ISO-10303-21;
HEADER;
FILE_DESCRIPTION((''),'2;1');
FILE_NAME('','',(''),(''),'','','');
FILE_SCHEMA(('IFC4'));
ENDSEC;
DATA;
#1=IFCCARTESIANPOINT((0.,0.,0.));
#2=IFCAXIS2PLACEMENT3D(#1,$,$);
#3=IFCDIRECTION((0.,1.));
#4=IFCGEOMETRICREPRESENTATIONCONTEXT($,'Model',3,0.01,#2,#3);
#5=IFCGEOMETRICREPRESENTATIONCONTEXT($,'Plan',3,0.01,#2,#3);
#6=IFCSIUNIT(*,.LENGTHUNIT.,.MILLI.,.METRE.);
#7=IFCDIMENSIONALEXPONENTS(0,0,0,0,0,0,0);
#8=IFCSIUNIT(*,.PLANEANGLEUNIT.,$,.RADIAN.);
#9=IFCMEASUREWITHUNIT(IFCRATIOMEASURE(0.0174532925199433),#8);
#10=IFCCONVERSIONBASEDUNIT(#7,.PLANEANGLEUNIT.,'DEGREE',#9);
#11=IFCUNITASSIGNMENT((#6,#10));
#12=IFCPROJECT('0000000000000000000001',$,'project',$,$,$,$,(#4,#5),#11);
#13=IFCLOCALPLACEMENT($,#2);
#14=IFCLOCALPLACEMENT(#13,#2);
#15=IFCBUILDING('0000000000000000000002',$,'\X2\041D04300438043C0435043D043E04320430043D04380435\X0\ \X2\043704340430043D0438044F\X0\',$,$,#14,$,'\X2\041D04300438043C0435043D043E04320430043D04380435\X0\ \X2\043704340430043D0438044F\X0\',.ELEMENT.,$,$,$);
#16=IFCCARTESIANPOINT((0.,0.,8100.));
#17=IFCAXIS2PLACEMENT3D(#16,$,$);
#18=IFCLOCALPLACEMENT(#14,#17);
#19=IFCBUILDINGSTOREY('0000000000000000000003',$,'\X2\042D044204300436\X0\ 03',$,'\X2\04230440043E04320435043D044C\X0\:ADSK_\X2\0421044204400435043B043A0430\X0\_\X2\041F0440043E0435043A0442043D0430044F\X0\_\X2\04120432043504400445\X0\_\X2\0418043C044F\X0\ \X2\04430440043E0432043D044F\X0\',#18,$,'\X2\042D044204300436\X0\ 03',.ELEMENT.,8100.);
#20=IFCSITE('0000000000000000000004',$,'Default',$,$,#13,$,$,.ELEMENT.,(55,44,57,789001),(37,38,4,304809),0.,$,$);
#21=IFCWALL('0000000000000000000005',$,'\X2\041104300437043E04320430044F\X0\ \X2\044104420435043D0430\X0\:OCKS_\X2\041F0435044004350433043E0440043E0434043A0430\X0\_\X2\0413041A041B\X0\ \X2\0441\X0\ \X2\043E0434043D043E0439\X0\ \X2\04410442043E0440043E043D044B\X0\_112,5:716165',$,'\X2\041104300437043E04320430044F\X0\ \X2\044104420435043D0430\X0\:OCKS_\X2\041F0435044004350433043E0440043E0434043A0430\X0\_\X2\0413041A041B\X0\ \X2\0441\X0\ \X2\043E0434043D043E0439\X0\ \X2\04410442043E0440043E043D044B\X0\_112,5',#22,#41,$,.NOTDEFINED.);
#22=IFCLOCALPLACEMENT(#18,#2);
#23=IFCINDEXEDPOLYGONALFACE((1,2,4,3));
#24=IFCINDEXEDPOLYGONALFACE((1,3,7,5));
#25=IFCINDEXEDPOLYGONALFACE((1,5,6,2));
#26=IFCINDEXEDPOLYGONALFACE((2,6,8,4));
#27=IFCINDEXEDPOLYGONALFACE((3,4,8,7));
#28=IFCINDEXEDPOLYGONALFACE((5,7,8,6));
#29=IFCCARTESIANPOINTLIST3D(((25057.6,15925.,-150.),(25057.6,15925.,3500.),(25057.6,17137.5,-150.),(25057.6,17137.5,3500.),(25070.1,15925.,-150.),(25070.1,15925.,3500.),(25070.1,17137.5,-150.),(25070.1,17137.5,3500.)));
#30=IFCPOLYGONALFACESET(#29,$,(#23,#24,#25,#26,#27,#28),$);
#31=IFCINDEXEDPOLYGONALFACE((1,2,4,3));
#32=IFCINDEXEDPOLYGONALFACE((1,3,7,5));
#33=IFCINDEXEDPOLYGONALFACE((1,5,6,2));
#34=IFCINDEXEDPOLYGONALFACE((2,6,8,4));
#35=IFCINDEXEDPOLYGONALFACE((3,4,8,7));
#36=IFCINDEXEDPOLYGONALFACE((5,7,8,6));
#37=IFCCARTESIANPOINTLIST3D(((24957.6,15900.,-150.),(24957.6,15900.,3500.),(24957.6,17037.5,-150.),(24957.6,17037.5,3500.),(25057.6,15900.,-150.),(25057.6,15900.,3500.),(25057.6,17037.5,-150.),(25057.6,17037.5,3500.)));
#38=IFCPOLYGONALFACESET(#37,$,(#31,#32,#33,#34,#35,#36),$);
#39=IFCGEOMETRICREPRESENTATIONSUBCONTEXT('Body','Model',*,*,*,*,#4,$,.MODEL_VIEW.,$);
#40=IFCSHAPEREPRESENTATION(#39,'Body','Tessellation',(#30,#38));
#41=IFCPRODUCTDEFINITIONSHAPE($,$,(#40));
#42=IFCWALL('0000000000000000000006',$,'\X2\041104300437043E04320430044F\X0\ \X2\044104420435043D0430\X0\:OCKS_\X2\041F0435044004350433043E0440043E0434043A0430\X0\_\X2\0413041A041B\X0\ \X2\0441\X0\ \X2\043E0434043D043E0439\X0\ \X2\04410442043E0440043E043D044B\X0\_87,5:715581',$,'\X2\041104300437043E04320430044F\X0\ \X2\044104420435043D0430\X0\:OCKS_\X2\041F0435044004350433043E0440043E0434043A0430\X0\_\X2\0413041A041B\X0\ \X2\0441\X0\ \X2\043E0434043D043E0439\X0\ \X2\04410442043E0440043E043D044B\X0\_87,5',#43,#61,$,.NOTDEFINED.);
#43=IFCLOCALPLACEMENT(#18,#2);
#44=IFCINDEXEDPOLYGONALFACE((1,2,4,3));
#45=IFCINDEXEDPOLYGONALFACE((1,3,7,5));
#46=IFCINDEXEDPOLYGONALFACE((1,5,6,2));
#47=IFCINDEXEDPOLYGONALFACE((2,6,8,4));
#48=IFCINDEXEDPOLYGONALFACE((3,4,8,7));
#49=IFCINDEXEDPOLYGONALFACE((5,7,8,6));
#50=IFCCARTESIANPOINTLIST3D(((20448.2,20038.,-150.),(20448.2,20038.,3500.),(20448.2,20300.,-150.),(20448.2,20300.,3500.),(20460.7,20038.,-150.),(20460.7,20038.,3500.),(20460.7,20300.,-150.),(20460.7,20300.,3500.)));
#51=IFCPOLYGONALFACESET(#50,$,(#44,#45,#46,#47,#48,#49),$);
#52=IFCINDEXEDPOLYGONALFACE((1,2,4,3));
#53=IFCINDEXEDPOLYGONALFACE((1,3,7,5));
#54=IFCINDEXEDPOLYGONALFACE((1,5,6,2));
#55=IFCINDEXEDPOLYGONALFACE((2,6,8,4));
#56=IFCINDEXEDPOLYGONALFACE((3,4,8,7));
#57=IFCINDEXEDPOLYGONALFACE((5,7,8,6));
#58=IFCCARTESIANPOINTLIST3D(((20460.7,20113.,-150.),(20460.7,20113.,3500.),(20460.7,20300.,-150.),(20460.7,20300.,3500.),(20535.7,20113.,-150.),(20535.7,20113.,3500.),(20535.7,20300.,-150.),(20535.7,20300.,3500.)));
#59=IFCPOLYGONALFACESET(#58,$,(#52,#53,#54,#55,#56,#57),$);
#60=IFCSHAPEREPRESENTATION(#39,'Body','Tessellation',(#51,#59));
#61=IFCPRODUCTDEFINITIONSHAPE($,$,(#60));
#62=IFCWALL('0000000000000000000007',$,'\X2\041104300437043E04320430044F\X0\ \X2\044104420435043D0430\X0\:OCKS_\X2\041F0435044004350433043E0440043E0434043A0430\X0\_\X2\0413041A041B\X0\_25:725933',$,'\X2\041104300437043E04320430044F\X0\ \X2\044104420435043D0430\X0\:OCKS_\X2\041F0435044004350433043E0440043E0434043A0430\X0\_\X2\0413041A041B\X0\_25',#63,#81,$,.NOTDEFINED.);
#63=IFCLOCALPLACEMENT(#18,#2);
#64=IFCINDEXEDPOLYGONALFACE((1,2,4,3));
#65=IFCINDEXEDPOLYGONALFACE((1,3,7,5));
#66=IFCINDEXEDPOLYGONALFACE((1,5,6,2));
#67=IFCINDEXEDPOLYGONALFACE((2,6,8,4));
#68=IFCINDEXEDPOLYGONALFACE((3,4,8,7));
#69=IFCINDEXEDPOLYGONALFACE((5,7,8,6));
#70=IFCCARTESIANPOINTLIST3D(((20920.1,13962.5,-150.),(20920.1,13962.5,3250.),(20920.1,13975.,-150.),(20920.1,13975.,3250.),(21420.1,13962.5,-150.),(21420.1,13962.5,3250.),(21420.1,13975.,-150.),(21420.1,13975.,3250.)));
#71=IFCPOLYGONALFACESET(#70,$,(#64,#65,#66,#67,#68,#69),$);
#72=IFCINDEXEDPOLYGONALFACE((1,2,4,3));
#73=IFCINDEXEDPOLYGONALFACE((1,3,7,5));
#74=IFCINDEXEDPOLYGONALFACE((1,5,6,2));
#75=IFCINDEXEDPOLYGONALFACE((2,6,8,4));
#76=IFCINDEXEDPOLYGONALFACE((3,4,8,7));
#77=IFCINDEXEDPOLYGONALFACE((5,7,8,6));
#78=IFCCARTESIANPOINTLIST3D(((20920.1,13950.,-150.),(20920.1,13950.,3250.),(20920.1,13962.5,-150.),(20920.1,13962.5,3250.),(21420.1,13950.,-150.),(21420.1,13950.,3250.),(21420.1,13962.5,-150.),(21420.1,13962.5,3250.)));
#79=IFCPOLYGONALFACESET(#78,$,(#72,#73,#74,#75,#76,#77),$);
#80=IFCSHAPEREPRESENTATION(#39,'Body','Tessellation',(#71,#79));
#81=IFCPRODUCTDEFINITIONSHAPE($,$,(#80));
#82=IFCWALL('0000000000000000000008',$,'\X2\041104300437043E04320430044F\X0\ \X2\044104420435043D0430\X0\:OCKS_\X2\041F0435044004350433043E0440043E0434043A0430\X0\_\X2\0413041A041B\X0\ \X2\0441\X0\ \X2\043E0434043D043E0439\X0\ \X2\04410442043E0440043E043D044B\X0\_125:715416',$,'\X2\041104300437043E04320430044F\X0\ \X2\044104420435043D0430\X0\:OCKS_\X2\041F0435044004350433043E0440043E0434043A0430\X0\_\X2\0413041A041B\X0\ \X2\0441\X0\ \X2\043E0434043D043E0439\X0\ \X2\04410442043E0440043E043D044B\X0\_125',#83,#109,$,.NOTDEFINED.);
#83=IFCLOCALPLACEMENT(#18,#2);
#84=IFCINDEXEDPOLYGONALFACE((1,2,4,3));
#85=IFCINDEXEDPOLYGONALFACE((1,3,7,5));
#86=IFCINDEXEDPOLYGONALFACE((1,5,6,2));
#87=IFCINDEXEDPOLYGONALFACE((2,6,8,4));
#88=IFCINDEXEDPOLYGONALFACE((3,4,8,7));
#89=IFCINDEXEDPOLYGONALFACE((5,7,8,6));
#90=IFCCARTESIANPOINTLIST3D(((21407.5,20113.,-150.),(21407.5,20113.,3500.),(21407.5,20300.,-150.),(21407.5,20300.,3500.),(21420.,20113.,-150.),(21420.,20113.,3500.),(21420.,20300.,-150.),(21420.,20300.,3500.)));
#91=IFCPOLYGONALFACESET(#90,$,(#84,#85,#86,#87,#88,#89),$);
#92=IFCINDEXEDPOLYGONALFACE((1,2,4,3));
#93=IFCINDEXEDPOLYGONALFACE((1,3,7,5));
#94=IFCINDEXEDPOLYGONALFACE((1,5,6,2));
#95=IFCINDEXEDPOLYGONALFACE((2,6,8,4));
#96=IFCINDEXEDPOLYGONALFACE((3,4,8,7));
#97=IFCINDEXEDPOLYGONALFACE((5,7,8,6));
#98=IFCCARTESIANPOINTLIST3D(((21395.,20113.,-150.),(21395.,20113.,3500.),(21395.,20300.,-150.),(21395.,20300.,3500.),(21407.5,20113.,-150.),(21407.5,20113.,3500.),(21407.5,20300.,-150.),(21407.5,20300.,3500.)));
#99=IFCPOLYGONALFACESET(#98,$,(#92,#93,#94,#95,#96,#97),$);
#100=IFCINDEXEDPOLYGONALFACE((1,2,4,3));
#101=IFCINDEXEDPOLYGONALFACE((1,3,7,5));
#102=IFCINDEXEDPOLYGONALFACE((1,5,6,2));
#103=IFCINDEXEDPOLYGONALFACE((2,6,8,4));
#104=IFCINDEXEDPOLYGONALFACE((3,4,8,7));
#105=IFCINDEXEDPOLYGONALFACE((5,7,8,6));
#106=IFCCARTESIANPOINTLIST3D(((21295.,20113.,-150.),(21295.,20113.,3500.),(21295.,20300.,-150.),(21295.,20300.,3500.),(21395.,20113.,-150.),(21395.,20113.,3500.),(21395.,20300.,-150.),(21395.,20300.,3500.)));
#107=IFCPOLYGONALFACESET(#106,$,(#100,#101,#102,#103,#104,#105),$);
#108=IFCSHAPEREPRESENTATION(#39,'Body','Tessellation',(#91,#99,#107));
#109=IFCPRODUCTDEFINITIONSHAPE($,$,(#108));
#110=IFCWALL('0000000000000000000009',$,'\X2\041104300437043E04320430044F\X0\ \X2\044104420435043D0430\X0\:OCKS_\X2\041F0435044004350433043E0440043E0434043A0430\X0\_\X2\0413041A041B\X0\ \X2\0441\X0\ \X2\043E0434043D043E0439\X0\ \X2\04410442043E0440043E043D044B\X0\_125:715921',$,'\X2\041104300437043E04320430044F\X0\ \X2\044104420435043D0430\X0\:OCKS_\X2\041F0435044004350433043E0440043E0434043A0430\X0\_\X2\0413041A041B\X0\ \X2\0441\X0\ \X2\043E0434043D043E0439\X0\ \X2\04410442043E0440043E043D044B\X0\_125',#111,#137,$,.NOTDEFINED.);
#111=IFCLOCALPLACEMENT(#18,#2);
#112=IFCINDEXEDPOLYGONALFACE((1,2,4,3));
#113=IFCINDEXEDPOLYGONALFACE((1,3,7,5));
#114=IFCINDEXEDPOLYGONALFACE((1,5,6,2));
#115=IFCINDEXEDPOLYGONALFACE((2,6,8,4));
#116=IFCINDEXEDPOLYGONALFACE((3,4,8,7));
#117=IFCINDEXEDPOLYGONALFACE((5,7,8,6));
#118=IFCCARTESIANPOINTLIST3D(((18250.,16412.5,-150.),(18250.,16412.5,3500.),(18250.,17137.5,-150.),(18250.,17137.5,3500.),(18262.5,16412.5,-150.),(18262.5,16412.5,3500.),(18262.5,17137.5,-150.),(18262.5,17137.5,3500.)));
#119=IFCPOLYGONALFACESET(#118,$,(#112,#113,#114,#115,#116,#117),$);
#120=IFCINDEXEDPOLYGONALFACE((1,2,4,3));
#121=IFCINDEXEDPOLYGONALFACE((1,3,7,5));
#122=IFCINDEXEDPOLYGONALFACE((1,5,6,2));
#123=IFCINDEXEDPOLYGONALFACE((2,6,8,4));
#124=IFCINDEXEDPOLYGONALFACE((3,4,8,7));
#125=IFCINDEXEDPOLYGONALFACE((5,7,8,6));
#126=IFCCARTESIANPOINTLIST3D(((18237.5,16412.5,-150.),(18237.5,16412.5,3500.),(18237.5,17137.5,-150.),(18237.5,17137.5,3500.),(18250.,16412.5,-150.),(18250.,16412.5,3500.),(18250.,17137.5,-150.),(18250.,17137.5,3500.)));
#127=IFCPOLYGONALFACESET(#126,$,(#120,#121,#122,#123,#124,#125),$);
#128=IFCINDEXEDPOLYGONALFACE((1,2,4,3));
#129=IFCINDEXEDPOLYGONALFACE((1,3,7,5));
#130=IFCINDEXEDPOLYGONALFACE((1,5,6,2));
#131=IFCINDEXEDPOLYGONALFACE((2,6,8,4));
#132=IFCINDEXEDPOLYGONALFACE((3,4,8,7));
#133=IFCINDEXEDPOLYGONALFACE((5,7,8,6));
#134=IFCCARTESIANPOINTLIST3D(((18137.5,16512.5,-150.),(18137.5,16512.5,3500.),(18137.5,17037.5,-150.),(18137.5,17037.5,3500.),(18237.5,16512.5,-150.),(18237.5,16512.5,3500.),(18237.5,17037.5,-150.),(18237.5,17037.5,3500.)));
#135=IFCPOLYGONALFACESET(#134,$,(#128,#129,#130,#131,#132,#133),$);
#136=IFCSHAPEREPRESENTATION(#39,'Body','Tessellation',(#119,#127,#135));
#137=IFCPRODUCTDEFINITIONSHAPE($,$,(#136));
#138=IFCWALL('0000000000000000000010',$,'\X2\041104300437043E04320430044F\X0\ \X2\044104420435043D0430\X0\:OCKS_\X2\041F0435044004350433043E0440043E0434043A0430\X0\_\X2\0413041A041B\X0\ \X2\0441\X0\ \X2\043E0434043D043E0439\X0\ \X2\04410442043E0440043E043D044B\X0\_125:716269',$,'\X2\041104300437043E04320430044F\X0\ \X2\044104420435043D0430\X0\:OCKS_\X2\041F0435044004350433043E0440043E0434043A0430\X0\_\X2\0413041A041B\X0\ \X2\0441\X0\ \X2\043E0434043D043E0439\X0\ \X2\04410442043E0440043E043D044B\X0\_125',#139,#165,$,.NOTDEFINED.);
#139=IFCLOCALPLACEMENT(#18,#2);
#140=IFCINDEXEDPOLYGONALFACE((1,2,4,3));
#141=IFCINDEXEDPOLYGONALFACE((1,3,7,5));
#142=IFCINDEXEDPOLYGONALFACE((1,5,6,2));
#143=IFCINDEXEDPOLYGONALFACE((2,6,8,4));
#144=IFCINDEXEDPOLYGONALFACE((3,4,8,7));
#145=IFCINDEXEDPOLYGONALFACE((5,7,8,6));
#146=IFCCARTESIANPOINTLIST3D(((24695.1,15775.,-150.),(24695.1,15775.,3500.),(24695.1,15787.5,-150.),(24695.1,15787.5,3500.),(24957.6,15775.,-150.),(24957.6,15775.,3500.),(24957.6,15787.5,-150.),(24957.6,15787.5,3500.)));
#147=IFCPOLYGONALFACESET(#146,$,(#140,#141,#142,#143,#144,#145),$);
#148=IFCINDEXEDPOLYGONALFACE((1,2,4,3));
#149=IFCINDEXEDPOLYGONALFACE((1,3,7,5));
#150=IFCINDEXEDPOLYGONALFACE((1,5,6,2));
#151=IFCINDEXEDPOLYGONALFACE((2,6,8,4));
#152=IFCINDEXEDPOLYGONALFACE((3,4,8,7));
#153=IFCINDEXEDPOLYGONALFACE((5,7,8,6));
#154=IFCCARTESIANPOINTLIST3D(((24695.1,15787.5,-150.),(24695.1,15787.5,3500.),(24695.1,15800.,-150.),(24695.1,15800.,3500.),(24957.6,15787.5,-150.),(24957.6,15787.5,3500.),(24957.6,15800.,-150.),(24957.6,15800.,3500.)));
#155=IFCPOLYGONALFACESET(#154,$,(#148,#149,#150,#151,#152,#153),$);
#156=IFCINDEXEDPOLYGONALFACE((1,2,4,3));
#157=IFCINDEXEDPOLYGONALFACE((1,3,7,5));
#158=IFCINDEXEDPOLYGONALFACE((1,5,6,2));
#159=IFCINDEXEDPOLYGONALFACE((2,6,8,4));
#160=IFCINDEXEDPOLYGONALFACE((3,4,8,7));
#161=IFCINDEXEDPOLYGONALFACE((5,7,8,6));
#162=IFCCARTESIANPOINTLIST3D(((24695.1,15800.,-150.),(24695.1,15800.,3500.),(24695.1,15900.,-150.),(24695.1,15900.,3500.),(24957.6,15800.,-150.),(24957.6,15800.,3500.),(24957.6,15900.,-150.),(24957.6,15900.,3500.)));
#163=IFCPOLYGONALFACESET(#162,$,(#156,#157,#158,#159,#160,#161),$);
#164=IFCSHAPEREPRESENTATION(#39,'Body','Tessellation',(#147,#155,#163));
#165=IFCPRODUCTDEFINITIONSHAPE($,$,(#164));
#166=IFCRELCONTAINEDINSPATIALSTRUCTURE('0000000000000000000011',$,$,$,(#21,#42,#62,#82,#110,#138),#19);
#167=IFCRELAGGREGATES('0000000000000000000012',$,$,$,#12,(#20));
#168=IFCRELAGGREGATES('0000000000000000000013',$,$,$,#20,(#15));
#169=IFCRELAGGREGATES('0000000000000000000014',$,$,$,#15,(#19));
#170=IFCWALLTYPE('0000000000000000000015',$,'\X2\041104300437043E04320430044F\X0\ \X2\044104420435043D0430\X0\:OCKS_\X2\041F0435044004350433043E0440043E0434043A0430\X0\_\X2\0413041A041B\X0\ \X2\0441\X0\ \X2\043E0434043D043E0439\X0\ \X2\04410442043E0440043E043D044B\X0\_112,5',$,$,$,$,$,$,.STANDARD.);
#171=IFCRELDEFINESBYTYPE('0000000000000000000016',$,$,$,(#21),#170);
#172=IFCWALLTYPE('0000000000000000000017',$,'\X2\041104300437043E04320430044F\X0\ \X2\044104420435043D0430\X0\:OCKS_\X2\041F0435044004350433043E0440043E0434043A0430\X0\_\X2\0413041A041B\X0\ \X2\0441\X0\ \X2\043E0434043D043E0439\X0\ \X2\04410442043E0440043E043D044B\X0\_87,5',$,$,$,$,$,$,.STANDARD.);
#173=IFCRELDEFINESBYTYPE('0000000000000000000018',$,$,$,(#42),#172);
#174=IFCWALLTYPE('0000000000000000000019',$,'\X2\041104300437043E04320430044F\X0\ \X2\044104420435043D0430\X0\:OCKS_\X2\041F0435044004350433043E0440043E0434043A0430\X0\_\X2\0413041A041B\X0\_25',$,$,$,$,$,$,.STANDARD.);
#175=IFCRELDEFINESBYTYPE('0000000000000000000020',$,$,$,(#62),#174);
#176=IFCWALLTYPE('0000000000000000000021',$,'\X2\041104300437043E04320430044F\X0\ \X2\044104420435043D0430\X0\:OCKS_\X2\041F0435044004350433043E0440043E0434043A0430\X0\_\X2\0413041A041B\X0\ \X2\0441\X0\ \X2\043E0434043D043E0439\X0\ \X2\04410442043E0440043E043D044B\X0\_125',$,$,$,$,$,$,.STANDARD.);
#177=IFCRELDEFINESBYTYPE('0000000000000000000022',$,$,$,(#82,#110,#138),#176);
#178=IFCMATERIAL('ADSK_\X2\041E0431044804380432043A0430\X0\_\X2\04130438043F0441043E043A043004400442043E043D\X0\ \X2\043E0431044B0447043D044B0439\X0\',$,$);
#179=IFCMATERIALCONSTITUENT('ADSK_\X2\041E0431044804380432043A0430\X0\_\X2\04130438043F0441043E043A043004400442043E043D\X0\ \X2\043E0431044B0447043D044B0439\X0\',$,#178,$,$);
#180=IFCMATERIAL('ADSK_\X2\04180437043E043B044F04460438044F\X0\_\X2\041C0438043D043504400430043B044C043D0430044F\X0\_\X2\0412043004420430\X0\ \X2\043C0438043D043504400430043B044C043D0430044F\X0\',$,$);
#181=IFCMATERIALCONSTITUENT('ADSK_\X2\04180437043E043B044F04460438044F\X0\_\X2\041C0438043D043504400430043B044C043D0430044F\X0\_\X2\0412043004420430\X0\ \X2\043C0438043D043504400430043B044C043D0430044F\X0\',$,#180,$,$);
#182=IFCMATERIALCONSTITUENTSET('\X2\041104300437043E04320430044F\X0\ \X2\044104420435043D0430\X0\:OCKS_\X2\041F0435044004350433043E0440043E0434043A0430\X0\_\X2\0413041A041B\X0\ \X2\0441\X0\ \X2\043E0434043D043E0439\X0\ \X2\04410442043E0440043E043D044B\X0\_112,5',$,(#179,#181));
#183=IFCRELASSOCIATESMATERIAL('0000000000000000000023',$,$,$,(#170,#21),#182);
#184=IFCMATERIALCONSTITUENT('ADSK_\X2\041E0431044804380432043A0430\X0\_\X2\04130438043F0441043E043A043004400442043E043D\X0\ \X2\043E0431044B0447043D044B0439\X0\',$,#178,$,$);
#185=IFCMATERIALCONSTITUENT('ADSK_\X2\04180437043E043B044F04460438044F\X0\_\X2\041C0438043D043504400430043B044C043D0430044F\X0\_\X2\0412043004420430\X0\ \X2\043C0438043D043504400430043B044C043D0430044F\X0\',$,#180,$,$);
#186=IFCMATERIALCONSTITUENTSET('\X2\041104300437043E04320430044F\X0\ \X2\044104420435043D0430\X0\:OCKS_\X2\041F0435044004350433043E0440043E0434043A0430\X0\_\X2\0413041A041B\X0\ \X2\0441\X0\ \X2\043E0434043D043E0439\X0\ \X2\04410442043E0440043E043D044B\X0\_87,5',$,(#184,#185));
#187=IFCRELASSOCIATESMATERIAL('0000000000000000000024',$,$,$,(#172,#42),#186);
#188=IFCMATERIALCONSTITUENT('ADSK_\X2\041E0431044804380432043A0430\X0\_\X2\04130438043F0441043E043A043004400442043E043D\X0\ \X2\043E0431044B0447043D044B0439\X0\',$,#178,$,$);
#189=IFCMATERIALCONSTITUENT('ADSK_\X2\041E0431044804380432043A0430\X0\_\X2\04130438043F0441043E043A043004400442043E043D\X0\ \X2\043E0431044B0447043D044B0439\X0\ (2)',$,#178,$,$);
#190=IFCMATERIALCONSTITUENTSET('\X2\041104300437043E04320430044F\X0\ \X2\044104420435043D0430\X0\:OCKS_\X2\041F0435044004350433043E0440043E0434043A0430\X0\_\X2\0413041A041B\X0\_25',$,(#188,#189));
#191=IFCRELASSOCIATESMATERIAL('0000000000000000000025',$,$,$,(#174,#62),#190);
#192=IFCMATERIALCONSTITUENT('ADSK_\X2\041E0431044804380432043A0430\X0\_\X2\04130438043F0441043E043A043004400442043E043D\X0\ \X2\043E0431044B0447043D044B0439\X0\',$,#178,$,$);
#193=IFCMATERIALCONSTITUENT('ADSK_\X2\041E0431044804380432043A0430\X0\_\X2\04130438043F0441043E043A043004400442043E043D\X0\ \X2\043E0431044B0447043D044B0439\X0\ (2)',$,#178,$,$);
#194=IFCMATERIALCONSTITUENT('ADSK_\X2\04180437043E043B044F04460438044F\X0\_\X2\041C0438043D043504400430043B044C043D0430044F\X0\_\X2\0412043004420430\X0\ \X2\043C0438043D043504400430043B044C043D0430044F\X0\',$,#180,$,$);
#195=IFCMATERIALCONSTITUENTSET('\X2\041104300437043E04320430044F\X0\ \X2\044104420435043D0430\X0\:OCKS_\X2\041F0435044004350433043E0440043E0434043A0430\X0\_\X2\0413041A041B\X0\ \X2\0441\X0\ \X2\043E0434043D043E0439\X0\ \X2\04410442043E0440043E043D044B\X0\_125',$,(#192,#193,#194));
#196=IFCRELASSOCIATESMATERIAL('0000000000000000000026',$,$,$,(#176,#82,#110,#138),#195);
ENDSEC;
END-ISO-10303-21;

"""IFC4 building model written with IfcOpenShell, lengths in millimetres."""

from ifc_helpers import new_model, entity, si_unit, converted_unit, direction, frame, origin, place, context, subcontext, project, spatial, indexed_curve, outline, extrude, material, constituent, constituent_set, type_object, element, save


model = new_model("IFC4")

# Units and contexts
model_context = context("Model", 3, precision=0.01, world=origin(), true_north=direction((0.0, 1.0)))
plan_context = context("Plan", 3, precision=0.01, world=origin(), true_north=direction((0.0, 1.0)))
body_context = subcontext(model_context, "Body", "Model", "MODEL_VIEW")
ifc_project = project(units=[si_unit("LENGTHUNIT", "METRE", prefix="MILLI"), converted_unit("PLANEANGLEUNIT", "DEGREE", entity("IfcRatioMeasure", 0.0174532925199433), si_unit("PLANEANGLEUNIT", "RADIAN"), dimensions=[0, 0, 0, 0, 0, 0, 0])], contexts=[model_context, plan_context])

# Site, building, storey
site_placement = place(None, frame((0.0, 0.0, 0.0)))
site = spatial("IfcSite", under=ifc_project, at=site_placement, Name="Default", CompositionType="ELEMENT", RefLatitude=(55, 44, 57, 789001), RefLongitude=(37, 38, 4, 304809), RefElevation=0.0)
building_placement = place(site_placement, origin())
building = spatial("IfcBuilding", under=site, at=building_placement, Name="Наименование здания", LongName="Наименование здания", CompositionType="ELEMENT")
storey_placement = place(building_placement, frame((0.0, 0.0, 8100.0)))
storey = spatial("IfcBuildingStorey", under=building, at=storey_placement, Name="Этаж 03", ObjectType="Уровень:ADSK_Стрелка_Проектная_Вверх_Имя уровня", LongName="Этаж 03", CompositionType="ELEMENT", Elevation=8100.0)

# Shared definitions
ifc_material_1 = material(Name="ADSK_Обшивка_Гипсокартон обычный")
ifc_material_2 = material(Name="ADSK_Изоляция_Минеральная_Вата минеральная")

# Walls
ifc_constituent_1 = constituent(ifc_material_1, Name="ADSK_Обшивка_Гипсокартон обычный")
ifc_constituent_2 = constituent(ifc_material_2, Name="ADSK_Изоляция_Минеральная_Вата минеральная")
ifc_constituent_set_1 = constituent_set(constituents=[ifc_constituent_1, ifc_constituent_2], Name="Базовая стена:OCKS_Перегородка_ГКЛ с одной стороны_112,5")
wall_type_1 = type_object("IfcWallType", Name="Базовая стена:OCKS_Перегородка_ГКЛ с одной стороны_112,5", PredefinedType="STANDARD", material=ifc_constituent_set_1)
wall_1_placement = place(storey_placement, frame((25013.9, 17037.5, -150.0), z_axis=(0.0, 0.0, 1.0), x_axis=(0.0, -1.0, 0.0)))
element("IfcWall", 1, at=wall_1_placement, inside=storey, type_object=wall_type_1, material=ifc_constituent_set_1, Name="Базовая стена:OCKS_Перегородка_ГКЛ с одной стороны_112,5:716165", ObjectType="Базовая стена:OCKS_Перегородка_ГКЛ с одной стороны_112,5", PredefinedType="NOTDEFINED", context=body_context, shape_type="SweptSolid", body=[
    extrude(outline(indexed_curve([(-6.3, -606.2), (6.2, -606.2), (6.2, 606.2), (-6.3, 606.2), (-6.3, -606.2)], self_intersect=False)), frame((506.2, 50.0, 0.0), z_axis=(0.0, 0.0, 1.0), x_axis=(0.0, -1.0, 0.0)), (0.0, 0.0, 1.0), 3650.0),
    extrude(outline(indexed_curve([(-50.0, -568.7), (50.0, -568.7), (50.0, 568.7), (-50.0, 568.7), (-50.0, -568.7)], self_intersect=False)), frame((568.7, -6.3, 0.0), z_axis=(0.0, 0.0, 1.0), x_axis=(0.0, 1.0, 0.0)), (0.0, 0.0, 1.0), 3650.0),
])
ifc_constituent_3 = constituent(ifc_material_1, Name="ADSK_Обшивка_Гипсокартон обычный")
ifc_constituent_4 = constituent(ifc_material_2, Name="ADSK_Изоляция_Минеральная_Вата минеральная")
ifc_constituent_set_2 = constituent_set(constituents=[ifc_constituent_3, ifc_constituent_4], Name="Базовая стена:OCKS_Перегородка_ГКЛ с одной стороны_87,5")
wall_type_2 = type_object("IfcWallType", Name="Базовая стена:OCKS_Перегородка_ГКЛ с одной стороны_87,5", PredefinedType="STANDARD", material=ifc_constituent_set_2)
wall_2_placement = place(storey_placement, frame((20492.0, 20113.0, -150.0), z_axis=(0.0, 0.0, 1.0), x_axis=(0.0, 1.0, 0.0)))
element("IfcWall", 2, at=wall_2_placement, inside=storey, type_object=wall_type_2, material=ifc_constituent_set_2, Name="Базовая стена:OCKS_Перегородка_ГКЛ с одной стороны_87,5:715581", ObjectType="Базовая стена:OCKS_Перегородка_ГКЛ с одной стороны_87,5", PredefinedType="NOTDEFINED", context=body_context, shape_type="SweptSolid", body=[
    extrude(outline(indexed_curve([(-6.2, -131.0), (6.2, -131.0), (6.2, 131.0), (-6.2, 131.0), (-6.2, -131.0)], self_intersect=False)), frame((56.0, 37.5, 0.0), z_axis=(0.0, 0.0, 1.0), x_axis=(0.0, -1.0, 0.0)), (0.0, 0.0, 1.0), 3650.0),
    extrude(outline(indexed_curve([(-37.5, -93.5), (37.5, -93.5), (37.5, 93.5), (-37.5, 93.5), (-37.5, -93.5)], self_intersect=False)), frame((93.5, -6.2, 0.0), z_axis=(0.0, 0.0, 1.0), x_axis=(0.0, 1.0, 0.0)), (0.0, 0.0, 1.0), 3650.0),
])
ifc_constituent_5 = constituent(ifc_material_1, Name="ADSK_Обшивка_Гипсокартон обычный")
ifc_constituent_6 = constituent(ifc_material_1, Name="ADSK_Обшивка_Гипсокартон обычный (2)")
ifc_constituent_set_3 = constituent_set(constituents=[ifc_constituent_5, ifc_constituent_6], Name="Базовая стена:OCKS_Перегородка_ГКЛ_25")
wall_type_3 = type_object("IfcWallType", Name="Базовая стена:OCKS_Перегородка_ГКЛ_25", PredefinedType="STANDARD", material=ifc_constituent_set_3)
wall_3_placement = place(storey_placement, frame((20920.1, 13962.5, -150.0)))
element("IfcWall", 3, at=wall_3_placement, inside=storey, type_object=wall_type_3, material=ifc_constituent_set_3, Name="Базовая стена:OCKS_Перегородка_ГКЛ_25:725933", ObjectType="Базовая стена:OCKS_Перегородка_ГКЛ_25", PredefinedType="NOTDEFINED", context=body_context, shape_type="SweptSolid", body=[
    extrude(outline(indexed_curve([(-6.3, -250.0), (6.2, -250.0), (6.3, 250.0), (-6.2, 250.0), (-6.3, -250.0)], self_intersect=False)), frame((250.0, 6.3, 0.0), z_axis=(0.0, 0.0, 1.0), x_axis=(0.0, -1.0, 0.0)), (0.0, 0.0, 1.0), 3400.0),
    extrude(outline(indexed_curve([(-6.3, -250.0), (6.3, -250.0), (6.3, 250.0), (-6.2, 250.0), (-6.3, -250.0)], self_intersect=False)), frame((250.0, -6.3, 0.0), z_axis=(0.0, 0.0, 1.0), x_axis=(0.0, 1.0, 0.0)), (0.0, 0.0, 1.0), 3400.0),
])
ifc_constituent_7 = constituent(ifc_material_1, Name="ADSK_Обшивка_Гипсокартон обычный")
ifc_constituent_8 = constituent(ifc_material_1, Name="ADSK_Обшивка_Гипсокартон обычный (2)")
ifc_constituent_9 = constituent(ifc_material_2, Name="ADSK_Изоляция_Минеральная_Вата минеральная")
ifc_constituent_set_4 = constituent_set(constituents=[ifc_constituent_7, ifc_constituent_8, ifc_constituent_9], Name="Базовая стена:OCKS_Перегородка_ГКЛ с одной стороны_125")
wall_type_4 = type_object("IfcWallType", Name="Базовая стена:OCKS_Перегородка_ГКЛ с одной стороны_125", PredefinedType="STANDARD", material=ifc_constituent_set_4)
wall_4_placement = place(storey_placement, frame((21357.5, 20300.0, -150.0), z_axis=(0.0, 0.0, 1.0), x_axis=(0.0, -1.0, 0.0)))
element("IfcWall", 4, at=wall_4_placement, inside=storey, type_object=wall_type_4, material=ifc_constituent_set_4, Name="Базовая стена:OCKS_Перегородка_ГКЛ с одной стороны_125:715416", ObjectType="Базовая стена:OCKS_Перегородка_ГКЛ с одной стороны_125", PredefinedType="NOTDEFINED", context=body_context, shape_type="SweptSolid", body=[
    extrude(outline(indexed_curve([(-6.2, -93.5), (6.2, -93.5), (6.2, 93.5), (-6.2, 93.5), (-6.2, -93.5)], self_intersect=False)), frame((93.5, 56.3, 0.0), z_axis=(0.0, 0.0, 1.0), x_axis=(0.0, -1.0, 0.0)), (0.0, 0.0, 1.0), 3650.0),
    extrude(outline(indexed_curve([(-93.5, -6.2), (93.5, -6.2), (93.5, 6.3), (-93.5, 6.3), (-93.5, -6.2)], self_intersect=False)), frame((93.5, 43.7, 0.0)), (0.0, 0.0, 1.0), 3650.0),
    extrude(outline(indexed_curve([(-50.0, -93.5), (50.0, -93.5), (50.0, 93.5), (-50.0, 93.5), (-50.0, -93.5)], self_intersect=False)), frame((93.5, -12.5, 0.0), z_axis=(0.0, 0.0, 1.0), x_axis=(0.0, 1.0, 0.0)), (0.0, 0.0, 1.0), 3650.0),
])
wall_5_placement = place(storey_placement, frame((18200.0, 17037.5, -150.0), z_axis=(0.0, 0.0, 1.0), x_axis=(0.0, -1.0, 0.0)))
element("IfcWall", 5, at=wall_5_placement, inside=storey, type_object=wall_type_4, material=ifc_constituent_set_4, Name="Базовая стена:OCKS_Перегородка_ГКЛ с одной стороны_125:715921", ObjectType="Базовая стена:OCKS_Перегородка_ГКЛ с одной стороны_125", PredefinedType="NOTDEFINED", context=body_context, shape_type="SweptSolid", body=[
    extrude(outline(indexed_curve([(-6.3, -362.5), (6.3, -362.5), (6.3, 362.5), (-6.2, 362.5), (-6.3, -362.5)], self_intersect=False)), frame((262.5, 56.3, 0.0), z_axis=(0.0, 0.0, 1.0), x_axis=(0.0, -1.0, 0.0)), (0.0, 0.0, 1.0), 3650.0),
    extrude(outline(indexed_curve([(-362.5, -6.2), (362.5, -6.2), (362.5, 6.3), (-362.5, 6.3), (-362.5, -6.2)], self_intersect=False)), frame((262.5, 43.7, 0.0)), (0.0, 0.0, 1.0), 3650.0),
    extrude(outline(indexed_curve([(-50.0, -262.5), (50.0, -262.5), (50.0, 262.5), (-50.0, 262.5), (-50.0, -262.5)], self_intersect=False)), frame((262.5, -12.5, 0.0), z_axis=(0.0, 0.0, 1.0), x_axis=(0.0, 1.0, 0.0)), (0.0, 0.0, 1.0), 3650.0),
])
wall_6_placement = place(storey_placement, frame((24695.1, 15837.5, -150.0)))
element("IfcWall", 6, at=wall_6_placement, inside=storey, type_object=wall_type_4, material=ifc_constituent_set_4, Name="Базовая стена:OCKS_Перегородка_ГКЛ с одной стороны_125:716269", ObjectType="Базовая стена:OCKS_Перегородка_ГКЛ с одной стороны_125", PredefinedType="NOTDEFINED", context=body_context, shape_type="SweptSolid", body=[
    extrude(outline(indexed_curve([(-6.3, -131.2), (6.2, -131.2), (6.3, 131.2), (-6.2, 131.2), (-6.3, -131.2)], self_intersect=False)), frame((131.2, -56.3, 0.0), z_axis=(0.0, 0.0, 1.0), x_axis=(0.0, 1.0, 0.0)), (0.0, 0.0, 1.0), 3650.0),
    extrude(outline(indexed_curve([(-131.2, -6.2), (131.2, -6.2), (131.2, 6.2), (-131.2, 6.2), (-131.2, -6.2)], self_intersect=False)), frame((131.2, -43.8, 0.0)), (0.0, 0.0, 1.0), 3650.0),
    extrude(outline(indexed_curve([(-50.0, -131.2), (50.0, -131.2), (50.0, 131.2), (-50.0, 131.2), (-50.0, -131.2)], self_intersect=False)), frame((131.2, 12.5, 0.0), z_axis=(0.0, 0.0, 1.0), x_axis=(0.0, -1.0, 0.0)), (0.0, 0.0, 1.0), 3650.0),
])

save(model, "model.ifc")
